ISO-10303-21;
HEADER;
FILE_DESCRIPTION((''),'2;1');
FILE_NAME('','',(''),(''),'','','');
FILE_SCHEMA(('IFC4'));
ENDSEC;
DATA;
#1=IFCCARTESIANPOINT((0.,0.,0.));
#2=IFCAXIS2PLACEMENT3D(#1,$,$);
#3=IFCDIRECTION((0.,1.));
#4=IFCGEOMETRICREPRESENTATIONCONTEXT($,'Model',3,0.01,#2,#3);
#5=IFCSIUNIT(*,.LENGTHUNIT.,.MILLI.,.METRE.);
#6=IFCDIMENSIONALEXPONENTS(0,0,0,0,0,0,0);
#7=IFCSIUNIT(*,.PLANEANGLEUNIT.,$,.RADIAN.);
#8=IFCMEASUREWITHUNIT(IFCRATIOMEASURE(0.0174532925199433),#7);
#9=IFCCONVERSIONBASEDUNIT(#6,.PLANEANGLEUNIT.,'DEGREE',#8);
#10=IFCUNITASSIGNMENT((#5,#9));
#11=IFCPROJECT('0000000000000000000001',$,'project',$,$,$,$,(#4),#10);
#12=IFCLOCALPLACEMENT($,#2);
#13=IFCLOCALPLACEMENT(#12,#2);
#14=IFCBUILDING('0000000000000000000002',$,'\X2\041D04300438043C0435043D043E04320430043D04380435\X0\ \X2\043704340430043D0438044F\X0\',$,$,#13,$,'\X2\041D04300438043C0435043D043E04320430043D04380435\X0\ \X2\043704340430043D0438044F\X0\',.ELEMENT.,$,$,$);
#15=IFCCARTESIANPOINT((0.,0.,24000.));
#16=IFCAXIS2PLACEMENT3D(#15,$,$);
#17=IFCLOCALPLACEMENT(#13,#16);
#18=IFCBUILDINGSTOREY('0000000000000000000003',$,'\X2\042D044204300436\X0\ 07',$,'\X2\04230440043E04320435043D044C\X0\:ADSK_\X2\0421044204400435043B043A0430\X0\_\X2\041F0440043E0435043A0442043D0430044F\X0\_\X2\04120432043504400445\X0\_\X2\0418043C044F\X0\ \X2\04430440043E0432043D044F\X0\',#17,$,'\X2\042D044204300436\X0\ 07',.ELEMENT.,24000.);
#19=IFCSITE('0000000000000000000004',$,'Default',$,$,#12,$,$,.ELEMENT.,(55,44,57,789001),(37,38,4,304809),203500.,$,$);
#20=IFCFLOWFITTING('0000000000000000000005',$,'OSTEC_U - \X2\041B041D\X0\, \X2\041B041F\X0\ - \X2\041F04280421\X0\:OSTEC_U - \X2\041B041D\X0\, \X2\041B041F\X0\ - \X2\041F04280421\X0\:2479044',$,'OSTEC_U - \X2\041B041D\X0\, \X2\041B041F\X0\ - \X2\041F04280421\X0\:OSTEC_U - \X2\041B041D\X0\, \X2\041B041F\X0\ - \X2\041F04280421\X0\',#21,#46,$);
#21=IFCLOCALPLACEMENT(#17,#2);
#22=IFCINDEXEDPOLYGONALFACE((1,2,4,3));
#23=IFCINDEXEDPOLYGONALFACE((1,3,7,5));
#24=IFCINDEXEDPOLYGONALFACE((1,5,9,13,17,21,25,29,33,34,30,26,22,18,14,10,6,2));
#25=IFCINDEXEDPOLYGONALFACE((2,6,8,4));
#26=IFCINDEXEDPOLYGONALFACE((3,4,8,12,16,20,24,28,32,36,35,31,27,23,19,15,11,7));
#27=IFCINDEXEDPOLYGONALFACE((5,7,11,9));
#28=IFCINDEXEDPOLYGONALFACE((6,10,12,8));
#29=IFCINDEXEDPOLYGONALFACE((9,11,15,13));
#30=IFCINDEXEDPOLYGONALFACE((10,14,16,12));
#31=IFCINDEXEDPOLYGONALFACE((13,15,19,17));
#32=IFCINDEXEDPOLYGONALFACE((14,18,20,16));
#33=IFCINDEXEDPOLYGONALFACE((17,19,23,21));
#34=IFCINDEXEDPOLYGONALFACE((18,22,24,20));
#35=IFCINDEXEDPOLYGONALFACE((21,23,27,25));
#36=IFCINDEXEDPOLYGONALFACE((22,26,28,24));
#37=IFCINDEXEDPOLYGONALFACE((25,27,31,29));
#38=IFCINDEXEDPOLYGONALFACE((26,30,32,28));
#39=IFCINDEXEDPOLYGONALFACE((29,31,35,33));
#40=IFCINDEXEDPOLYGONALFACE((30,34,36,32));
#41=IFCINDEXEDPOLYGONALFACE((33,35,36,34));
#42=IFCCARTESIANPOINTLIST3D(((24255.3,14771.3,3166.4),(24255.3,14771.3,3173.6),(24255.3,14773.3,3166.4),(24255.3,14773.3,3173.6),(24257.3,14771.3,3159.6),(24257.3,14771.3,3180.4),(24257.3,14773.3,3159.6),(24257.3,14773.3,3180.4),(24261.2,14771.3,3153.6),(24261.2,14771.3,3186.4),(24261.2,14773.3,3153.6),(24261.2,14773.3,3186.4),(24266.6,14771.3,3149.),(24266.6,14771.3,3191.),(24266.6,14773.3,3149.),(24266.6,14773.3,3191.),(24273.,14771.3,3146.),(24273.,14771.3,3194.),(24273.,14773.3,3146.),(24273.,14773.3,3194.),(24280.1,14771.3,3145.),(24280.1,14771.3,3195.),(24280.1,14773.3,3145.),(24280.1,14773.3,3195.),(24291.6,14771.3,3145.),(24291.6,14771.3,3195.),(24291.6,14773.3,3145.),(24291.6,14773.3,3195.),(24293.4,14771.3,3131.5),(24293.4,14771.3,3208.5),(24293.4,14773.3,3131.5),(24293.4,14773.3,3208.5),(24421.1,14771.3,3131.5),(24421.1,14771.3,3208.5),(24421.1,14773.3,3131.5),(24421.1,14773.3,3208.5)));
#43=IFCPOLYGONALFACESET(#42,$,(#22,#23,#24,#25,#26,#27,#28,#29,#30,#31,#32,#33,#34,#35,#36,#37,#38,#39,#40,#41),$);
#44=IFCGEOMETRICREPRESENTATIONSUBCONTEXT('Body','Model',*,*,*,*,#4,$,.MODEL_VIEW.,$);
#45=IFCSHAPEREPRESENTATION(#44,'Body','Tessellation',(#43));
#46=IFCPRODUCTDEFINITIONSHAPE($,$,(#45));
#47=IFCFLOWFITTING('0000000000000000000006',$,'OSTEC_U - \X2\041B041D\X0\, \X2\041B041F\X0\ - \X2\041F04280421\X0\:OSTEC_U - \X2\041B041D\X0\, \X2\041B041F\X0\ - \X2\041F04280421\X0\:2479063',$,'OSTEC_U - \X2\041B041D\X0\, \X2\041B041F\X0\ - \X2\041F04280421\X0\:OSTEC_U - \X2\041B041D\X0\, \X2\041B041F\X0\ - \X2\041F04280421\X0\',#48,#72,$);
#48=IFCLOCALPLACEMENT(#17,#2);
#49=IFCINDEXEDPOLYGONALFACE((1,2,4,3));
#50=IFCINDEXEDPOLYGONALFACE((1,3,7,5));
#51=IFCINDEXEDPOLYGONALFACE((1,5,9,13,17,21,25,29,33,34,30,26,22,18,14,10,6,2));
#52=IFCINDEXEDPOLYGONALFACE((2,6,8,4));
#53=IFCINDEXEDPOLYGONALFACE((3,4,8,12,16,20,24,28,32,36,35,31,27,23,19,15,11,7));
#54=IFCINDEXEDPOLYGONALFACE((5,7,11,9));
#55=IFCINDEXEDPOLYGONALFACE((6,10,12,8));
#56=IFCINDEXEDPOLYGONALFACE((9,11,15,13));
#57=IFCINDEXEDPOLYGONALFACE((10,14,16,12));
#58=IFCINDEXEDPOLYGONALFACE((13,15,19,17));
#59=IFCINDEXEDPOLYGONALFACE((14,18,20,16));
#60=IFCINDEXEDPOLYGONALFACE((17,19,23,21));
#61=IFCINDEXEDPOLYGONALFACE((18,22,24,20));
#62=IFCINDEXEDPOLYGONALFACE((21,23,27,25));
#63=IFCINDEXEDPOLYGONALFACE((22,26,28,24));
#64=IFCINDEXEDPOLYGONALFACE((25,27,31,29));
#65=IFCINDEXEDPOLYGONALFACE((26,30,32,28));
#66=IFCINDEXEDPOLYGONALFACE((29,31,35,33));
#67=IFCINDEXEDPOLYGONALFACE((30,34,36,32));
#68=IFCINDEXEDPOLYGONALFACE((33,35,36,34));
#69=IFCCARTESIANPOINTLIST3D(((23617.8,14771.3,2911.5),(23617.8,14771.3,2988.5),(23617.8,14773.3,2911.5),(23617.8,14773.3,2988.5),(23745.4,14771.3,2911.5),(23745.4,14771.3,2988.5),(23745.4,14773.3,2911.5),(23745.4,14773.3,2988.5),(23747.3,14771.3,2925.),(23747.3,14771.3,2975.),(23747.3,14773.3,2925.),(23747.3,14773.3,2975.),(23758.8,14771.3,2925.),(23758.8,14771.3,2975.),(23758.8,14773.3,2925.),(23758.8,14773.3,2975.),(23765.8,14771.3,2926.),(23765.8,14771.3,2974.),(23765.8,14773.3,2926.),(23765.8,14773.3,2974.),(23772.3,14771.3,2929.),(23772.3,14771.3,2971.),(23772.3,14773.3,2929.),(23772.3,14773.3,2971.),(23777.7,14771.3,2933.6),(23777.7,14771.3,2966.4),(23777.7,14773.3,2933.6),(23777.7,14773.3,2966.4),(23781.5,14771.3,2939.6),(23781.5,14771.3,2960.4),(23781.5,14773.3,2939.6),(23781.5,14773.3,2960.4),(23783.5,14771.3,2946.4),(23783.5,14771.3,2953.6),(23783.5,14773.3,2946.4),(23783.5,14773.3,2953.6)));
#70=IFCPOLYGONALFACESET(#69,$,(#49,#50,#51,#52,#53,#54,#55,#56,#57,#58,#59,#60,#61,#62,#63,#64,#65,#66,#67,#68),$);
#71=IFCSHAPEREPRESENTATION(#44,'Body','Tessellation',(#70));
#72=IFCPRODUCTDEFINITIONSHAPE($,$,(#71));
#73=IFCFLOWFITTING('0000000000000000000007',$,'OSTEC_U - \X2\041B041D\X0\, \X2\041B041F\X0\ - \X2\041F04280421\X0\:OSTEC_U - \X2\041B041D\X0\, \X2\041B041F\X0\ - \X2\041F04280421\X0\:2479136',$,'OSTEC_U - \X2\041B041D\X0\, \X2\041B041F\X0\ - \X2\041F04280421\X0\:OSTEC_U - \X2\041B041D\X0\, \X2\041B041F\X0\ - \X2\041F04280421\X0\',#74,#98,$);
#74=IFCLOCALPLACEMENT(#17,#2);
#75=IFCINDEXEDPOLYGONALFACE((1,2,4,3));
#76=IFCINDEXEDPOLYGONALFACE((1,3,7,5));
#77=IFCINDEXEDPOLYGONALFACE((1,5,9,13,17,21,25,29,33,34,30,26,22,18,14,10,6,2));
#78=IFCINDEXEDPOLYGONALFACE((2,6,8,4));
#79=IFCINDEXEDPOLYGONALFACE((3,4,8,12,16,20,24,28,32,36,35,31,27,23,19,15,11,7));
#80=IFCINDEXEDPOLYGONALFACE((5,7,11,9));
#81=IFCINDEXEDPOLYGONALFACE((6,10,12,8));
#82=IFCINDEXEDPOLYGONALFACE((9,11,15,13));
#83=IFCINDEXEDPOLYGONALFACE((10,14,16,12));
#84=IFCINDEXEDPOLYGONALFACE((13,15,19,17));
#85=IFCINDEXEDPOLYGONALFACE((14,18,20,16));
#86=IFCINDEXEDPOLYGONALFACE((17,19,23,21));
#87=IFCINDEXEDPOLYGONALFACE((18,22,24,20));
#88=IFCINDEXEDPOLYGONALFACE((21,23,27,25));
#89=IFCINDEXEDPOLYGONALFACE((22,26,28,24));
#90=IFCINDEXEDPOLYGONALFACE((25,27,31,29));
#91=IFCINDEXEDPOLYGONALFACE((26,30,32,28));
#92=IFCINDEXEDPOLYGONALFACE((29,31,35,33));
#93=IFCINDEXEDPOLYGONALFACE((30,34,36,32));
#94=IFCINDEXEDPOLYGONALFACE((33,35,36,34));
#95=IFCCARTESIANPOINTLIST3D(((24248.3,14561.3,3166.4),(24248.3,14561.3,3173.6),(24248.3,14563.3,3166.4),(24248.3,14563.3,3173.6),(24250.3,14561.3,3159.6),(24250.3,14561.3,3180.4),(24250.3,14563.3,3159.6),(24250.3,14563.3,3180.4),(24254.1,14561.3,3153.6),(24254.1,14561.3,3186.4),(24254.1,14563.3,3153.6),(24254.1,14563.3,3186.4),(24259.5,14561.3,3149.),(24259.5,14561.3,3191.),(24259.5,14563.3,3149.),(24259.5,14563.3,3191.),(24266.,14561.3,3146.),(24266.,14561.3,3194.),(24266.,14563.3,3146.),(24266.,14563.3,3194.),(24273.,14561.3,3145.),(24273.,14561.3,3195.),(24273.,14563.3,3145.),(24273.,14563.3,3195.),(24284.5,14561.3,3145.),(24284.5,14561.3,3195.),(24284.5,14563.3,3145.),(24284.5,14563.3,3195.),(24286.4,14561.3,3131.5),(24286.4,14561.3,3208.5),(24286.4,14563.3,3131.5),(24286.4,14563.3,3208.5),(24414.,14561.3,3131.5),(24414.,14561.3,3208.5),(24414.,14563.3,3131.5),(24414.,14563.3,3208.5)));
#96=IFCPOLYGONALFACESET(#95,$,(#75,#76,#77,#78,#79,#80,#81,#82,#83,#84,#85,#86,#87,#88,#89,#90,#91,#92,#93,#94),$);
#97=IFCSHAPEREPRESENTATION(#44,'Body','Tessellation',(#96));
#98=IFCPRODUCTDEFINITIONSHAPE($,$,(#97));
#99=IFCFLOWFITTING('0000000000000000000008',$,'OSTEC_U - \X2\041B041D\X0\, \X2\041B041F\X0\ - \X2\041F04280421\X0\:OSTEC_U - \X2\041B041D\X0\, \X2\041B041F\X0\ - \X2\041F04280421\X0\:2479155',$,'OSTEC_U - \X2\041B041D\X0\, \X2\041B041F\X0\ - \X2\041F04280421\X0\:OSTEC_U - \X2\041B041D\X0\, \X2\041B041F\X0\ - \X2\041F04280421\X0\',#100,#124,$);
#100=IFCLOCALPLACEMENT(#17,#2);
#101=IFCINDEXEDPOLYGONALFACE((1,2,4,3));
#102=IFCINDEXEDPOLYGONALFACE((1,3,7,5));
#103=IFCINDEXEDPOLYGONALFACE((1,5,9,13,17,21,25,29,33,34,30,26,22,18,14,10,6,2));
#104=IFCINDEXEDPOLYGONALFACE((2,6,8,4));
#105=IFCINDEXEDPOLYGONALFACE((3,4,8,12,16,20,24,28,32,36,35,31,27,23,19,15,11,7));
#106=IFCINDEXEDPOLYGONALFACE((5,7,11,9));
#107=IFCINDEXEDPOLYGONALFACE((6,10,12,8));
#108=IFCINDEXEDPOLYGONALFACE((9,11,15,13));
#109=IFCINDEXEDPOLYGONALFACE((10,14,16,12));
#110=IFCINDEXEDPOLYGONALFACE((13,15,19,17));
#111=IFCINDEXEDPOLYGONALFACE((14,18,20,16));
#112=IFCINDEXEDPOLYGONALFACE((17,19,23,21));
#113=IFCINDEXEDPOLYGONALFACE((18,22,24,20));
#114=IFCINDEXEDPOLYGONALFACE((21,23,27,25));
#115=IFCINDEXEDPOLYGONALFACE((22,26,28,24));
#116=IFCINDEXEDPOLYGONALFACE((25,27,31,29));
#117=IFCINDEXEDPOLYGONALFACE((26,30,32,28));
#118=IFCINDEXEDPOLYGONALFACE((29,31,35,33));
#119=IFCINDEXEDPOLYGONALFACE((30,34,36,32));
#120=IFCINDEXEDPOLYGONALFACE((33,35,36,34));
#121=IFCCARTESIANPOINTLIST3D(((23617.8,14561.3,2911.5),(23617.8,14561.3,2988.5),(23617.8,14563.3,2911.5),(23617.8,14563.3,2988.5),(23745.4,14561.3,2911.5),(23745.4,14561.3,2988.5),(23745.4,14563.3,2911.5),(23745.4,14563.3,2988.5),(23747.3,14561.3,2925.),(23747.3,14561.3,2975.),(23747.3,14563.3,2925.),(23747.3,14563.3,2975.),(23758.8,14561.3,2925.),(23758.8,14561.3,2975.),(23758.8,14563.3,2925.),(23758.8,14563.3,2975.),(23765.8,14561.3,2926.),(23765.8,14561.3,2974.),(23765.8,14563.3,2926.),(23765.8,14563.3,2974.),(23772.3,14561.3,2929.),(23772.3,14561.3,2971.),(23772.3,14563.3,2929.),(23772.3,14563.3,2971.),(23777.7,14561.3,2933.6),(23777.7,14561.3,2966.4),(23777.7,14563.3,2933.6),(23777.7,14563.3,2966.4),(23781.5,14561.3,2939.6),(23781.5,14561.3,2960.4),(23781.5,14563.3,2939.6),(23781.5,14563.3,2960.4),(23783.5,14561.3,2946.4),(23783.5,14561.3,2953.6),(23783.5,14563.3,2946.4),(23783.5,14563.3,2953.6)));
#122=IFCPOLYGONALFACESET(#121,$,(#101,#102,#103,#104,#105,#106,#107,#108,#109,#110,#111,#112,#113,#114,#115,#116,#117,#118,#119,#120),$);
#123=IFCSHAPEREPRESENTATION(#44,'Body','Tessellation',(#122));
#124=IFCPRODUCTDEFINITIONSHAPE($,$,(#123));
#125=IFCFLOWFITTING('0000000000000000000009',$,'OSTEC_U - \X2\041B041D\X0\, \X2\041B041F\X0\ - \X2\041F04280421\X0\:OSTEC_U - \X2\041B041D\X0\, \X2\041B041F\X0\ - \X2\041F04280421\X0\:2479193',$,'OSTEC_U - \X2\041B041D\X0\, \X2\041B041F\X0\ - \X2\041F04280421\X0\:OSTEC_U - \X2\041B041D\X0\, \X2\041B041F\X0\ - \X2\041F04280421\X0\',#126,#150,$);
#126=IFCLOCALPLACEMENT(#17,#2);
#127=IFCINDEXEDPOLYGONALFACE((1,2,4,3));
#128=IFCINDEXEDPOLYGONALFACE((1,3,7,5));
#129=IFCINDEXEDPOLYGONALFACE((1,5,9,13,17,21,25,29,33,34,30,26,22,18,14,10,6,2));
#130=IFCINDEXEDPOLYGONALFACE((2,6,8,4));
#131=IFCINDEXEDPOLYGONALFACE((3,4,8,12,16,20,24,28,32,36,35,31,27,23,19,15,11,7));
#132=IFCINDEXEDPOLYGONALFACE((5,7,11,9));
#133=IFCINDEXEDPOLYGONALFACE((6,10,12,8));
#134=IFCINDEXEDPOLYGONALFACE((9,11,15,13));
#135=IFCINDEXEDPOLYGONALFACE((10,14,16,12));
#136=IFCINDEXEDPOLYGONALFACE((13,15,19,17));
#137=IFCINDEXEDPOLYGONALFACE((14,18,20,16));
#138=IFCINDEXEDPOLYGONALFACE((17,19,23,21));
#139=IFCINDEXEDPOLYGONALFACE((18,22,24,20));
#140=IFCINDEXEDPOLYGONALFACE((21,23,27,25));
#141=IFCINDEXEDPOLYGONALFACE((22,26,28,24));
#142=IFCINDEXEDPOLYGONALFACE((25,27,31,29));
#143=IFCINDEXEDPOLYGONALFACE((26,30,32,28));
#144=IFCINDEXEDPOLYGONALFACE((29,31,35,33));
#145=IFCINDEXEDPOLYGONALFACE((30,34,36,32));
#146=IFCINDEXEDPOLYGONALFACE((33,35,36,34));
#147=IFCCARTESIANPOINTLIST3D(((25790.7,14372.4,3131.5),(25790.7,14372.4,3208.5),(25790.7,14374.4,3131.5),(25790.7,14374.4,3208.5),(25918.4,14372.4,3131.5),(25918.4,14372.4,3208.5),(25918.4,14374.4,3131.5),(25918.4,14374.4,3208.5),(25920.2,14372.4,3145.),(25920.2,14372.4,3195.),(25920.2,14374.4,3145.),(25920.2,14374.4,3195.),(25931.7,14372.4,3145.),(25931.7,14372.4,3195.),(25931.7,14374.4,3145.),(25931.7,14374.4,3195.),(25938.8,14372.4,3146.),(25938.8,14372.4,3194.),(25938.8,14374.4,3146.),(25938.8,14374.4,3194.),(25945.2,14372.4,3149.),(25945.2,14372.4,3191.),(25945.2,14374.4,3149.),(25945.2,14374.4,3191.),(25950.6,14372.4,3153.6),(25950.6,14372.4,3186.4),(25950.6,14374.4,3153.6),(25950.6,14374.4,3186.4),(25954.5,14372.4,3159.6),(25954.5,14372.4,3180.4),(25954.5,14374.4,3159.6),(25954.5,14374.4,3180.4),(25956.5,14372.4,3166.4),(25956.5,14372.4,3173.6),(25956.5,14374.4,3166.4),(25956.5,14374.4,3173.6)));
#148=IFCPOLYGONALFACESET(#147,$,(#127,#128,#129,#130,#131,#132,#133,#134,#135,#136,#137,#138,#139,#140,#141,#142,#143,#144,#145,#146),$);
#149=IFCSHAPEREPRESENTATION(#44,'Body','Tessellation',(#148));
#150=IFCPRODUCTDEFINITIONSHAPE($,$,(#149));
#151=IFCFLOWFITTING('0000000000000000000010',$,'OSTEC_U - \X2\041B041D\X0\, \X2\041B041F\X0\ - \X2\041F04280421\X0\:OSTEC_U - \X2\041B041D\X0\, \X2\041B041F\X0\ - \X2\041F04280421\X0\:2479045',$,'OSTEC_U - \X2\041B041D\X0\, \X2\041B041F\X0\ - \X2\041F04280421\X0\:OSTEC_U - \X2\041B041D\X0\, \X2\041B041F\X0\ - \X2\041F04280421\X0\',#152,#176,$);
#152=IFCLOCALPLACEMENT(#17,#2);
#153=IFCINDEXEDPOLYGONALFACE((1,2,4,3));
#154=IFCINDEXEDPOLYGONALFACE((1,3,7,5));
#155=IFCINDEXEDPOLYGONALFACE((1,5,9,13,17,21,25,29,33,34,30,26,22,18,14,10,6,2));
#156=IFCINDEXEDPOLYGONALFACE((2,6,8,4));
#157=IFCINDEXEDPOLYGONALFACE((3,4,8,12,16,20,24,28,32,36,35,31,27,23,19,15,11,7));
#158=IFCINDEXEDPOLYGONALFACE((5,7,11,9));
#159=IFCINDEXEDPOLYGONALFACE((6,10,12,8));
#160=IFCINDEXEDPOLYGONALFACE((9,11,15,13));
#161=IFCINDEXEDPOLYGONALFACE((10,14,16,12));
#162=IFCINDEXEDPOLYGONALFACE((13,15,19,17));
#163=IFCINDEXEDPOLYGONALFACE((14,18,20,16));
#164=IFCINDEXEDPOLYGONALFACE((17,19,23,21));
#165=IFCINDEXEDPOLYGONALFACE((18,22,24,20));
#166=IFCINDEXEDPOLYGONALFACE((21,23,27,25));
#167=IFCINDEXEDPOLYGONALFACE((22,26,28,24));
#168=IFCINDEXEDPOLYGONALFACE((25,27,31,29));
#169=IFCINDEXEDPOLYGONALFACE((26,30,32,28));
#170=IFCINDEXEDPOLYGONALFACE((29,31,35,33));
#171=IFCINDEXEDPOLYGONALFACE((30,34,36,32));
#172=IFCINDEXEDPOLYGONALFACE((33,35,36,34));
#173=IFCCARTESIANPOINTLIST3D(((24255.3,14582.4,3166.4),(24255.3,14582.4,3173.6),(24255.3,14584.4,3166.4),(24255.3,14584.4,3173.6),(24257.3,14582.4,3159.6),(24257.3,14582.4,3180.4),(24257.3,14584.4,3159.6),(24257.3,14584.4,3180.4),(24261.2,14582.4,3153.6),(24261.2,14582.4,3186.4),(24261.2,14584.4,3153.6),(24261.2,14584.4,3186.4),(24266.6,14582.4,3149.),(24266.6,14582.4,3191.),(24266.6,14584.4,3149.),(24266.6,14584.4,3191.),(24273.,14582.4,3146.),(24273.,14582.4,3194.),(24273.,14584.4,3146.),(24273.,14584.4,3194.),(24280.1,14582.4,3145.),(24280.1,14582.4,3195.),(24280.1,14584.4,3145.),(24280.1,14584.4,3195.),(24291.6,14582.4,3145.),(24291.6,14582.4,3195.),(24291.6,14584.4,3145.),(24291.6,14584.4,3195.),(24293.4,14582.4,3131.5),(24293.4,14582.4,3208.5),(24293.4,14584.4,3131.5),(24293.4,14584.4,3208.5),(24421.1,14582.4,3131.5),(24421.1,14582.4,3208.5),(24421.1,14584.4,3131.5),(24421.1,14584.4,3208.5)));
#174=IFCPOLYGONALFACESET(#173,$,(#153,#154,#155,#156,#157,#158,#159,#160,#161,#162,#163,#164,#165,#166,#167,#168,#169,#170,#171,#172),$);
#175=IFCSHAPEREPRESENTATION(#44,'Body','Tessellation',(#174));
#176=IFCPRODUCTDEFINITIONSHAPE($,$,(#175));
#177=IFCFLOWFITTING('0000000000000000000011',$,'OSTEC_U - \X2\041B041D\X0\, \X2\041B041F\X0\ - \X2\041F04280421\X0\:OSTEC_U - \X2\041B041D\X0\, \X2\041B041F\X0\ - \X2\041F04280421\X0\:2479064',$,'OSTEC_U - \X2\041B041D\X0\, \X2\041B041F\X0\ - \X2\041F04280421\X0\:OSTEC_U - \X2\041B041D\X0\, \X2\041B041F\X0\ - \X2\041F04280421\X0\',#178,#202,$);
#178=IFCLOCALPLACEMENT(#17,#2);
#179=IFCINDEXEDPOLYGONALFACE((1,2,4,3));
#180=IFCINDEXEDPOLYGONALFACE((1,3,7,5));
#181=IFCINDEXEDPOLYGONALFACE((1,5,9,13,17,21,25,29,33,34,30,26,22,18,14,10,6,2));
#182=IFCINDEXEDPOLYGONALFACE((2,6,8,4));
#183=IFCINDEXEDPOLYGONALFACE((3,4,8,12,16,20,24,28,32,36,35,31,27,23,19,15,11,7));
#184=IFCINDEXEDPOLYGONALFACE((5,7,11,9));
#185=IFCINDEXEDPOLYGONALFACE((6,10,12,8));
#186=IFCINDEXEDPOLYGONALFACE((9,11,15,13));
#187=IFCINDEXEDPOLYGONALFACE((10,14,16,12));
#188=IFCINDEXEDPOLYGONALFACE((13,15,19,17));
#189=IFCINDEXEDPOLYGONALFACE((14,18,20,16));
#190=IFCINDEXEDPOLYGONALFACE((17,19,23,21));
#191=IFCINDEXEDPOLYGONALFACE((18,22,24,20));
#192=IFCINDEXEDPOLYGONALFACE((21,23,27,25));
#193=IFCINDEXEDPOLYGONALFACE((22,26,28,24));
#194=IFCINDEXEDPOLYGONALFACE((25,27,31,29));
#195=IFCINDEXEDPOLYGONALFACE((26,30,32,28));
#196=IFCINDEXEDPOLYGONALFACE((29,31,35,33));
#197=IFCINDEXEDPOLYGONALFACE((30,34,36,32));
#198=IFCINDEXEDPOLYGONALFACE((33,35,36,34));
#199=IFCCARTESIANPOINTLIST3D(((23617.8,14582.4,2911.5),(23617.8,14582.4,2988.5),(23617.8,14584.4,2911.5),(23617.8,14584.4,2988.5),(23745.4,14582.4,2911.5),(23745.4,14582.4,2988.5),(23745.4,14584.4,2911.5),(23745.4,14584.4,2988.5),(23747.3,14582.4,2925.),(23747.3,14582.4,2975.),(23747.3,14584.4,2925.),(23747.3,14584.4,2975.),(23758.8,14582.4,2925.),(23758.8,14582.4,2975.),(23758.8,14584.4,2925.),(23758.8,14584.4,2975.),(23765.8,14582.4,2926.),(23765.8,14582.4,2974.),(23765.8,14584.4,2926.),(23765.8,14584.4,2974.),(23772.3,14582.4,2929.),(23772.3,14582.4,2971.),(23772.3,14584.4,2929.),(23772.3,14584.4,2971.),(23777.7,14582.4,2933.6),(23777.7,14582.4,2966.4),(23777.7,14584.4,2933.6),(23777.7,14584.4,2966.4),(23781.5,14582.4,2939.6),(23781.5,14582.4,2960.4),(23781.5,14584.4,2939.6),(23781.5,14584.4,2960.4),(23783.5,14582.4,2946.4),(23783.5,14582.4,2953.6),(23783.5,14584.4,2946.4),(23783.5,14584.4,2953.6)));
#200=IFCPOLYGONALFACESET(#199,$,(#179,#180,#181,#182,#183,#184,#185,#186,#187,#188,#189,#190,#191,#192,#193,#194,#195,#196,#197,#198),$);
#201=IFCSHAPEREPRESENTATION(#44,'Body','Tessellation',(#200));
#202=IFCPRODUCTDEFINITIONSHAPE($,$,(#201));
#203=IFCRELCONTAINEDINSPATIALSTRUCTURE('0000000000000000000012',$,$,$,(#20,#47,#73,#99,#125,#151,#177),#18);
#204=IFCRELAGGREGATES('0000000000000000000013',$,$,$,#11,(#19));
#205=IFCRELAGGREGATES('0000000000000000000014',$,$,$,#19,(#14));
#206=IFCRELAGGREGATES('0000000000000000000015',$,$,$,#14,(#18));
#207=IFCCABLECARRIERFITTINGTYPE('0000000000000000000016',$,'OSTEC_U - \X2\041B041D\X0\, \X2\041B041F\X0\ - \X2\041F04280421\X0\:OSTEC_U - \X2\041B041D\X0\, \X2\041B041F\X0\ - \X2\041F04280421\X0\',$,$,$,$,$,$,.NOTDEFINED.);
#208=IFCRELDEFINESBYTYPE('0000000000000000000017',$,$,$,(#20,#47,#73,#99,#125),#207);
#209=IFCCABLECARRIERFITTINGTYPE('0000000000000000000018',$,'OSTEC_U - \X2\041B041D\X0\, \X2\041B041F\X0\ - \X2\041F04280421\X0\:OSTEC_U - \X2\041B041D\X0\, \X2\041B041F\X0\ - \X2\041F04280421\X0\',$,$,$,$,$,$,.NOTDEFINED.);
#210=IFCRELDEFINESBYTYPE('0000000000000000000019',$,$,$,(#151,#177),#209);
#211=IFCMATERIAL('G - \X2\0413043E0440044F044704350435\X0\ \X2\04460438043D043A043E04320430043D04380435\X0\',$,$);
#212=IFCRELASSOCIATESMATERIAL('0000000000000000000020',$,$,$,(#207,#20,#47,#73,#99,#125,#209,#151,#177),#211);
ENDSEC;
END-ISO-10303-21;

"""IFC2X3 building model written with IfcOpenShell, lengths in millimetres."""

from ifc_helpers import new_model, entity, si_unit, converted_unit, direction, frame, frame_2d, origin, place, context, subcontext, project, spatial, polyline, circle_curve, parameter, trimmed, segment, composite_curve, outline, extrude, source, transform, mapped, material, type_object, type_shapes, element, save


model = new_model("IFC2X3")

# Units and contexts
model_context = context("Model", 3, precision=0.01, world=origin(), true_north=direction((0.0, 1.0)))
body_context = subcontext(model_context, "Body", "Model", "MODEL_VIEW")
ifc_project = project(units=[si_unit("LENGTHUNIT", "METRE", prefix="MILLI"), converted_unit("PLANEANGLEUNIT", "DEGREE", entity("IfcRatioMeasure", 0.0174532925199433), si_unit("PLANEANGLEUNIT", "RADIAN"), dimensions=[0, 0, 0, 0, 0, 0, 0])], contexts=[model_context])

# Site, building, storey
site_placement = place(None, frame((0.0, 0.0, 0.0)))
site = spatial("IfcSite", under=ifc_project, at=site_placement, Name="Default", CompositionType="ELEMENT", RefLatitude=(55, 44, 57, 789001), RefLongitude=(37, 38, 4, 304809), RefElevation=203500.0)
building_placement = place(site_placement, origin())
building = spatial("IfcBuilding", under=site, at=building_placement, Name="Наименование здания", LongName="Наименование здания", CompositionType="ELEMENT")
storey_placement = place(building_placement, frame((0.0, 0.0, 24000.0)))
storey = spatial("IfcBuildingStorey", under=building, at=storey_placement, Name="Этаж 07", ObjectType="Уровень:ADSK_Стрелка_Проектная_Вверх_Имя уровня", LongName="Этаж 07", CompositionType="ELEMENT", Elevation=24000.0)

# Flow fittings
ifc_material_1 = material(Name="G - Горячее цинкование")
cable_carrier_fitting_type_1 = type_object("IfcCableCarrierFittingType", Name="OSTEC_U - ЛН, ЛП - ПШС:OSTEC_U - ЛН, ЛП - ПШС", PredefinedType="NOTDEFINED", material=ifc_material_1)
shared_shape_1 = source(origin(), body_context, "Body", "SweptSolid", [
    extrude(outline(composite_curve([segment(trimmed(circle_curve(frame_2d((-41.5, 0.0), x_axis=(1.0, 0.0)), 25.0), [parameter(90.0)], [parameter(270.0)], True, "PARAMETER"), True, "CONTINUOUS"), segment(polyline([(-41.5, -25.0), (-30.0, -25.0)]), True, "CONTINUOUS"), segment(polyline([(-30.0, -25.0), (-28.1, -38.5)]), True, "CONTINUOUS"), segment(polyline([(-28.1, -38.5), (99.5, -38.5)]), True, "CONTINUOUS"), segment(polyline([(99.5, -38.5), (99.5, 38.5)]), True, "CONTINUOUS"), segment(polyline([(99.5, 38.5), (-28.1, 38.5)]), True, "CONTINUOUS"), segment(polyline([(-28.1, 38.5), (-30.0, 25.0)]), True, "CONTINUOUS"), segment(polyline([(-30.0, 25.0), (-41.5, 25.0)]), True, "CONTINUOUS")], self_intersect=False)), frame((41.5, 0.0, 0.0), z_axis=(0.0, 0.0, -1.0), x_axis=(1.0, 0.0, 0.0)), (0.0, 0.0, -1.0), 2.0),
])
type_shapes(cable_carrier_fitting_type_1, [shared_shape_1])
for number, where, z_axis, x_axis, name in (
    (1, (24280.1, 14771.3, 3170.0), (0.0, 1.0, 0.0), (1.0, 0.0, 0.0), "OSTEC_U - ЛН, ЛП - ПШС:OSTEC_U - ЛН, ЛП - ПШС:2479044"),
    (2, (23758.8, 14771.3, 2950.0), (0.0, 1.0, 0.0), (-1.0, 0.0, 0.0), "OSTEC_U - ЛН, ЛП - ПШС:OSTEC_U - ЛН, ЛП - ПШС:2479063"),
    (3, (24273.0, 14561.3, 3170.0), (0.0, 1.0, 0.0), (1.0, 0.0, 0.0), "OSTEC_U - ЛН, ЛП - ПШС:OSTEC_U - ЛН, ЛП - ПШС:2479136"),
    (4, (23758.8, 14561.3, 2950.0), (0.0, 1.0, 0.0), (-1.0, 0.0, 0.0), "OSTEC_U - ЛН, ЛП - ПШС:OSTEC_U - ЛН, ЛП - ПШС:2479155"),
    (5, (25931.7, 14374.4, 3170.0), (0.0, -1.0, 0.0), (-1.0, 0.0, 0.0), "OSTEC_U - ЛН, ЛП - ПШС:OSTEC_U - ЛН, ЛП - ПШС:2479193"),
):
    element("IfcFlowFitting", number, at=place(storey_placement, frame(where, z_axis=z_axis, x_axis=x_axis)), inside=storey, type_object=cable_carrier_fitting_type_1, material=ifc_material_1, Name=name, ObjectType="OSTEC_U - ЛН, ЛП - ПШС:OSTEC_U - ЛН, ЛП - ПШС", context=body_context, shape_type="MappedRepresentation", body=[
        mapped(shared_shape_1, transform((0.0, 0.0, 0.0), scale=1.0)),
    ])
cable_carrier_fitting_type_2 = type_object("IfcCableCarrierFittingType", Name="OSTEC_U - ЛН, ЛП - ПШС:OSTEC_U - ЛН, ЛП - ПШС", PredefinedType="NOTDEFINED", material=ifc_material_1)
shared_shape_2 = source(origin(), body_context, "Body", "SweptSolid", [
    extrude(outline(composite_curve([segment(trimmed(circle_curve(frame_2d((-41.5, 0.0), x_axis=(1.0, 0.0)), 25.0), [parameter(90.0)], [parameter(270.0)], True, "PARAMETER"), True, "CONTINUOUS"), segment(polyline([(-41.5, -25.0), (-30.0, -25.0)]), True, "CONTINUOUS"), segment(polyline([(-30.0, -25.0), (-28.1, -38.5)]), True, "CONTINUOUS"), segment(polyline([(-28.1, -38.5), (99.5, -38.5)]), True, "CONTINUOUS"), segment(polyline([(99.5, -38.5), (99.5, 38.5)]), True, "CONTINUOUS"), segment(polyline([(99.5, 38.5), (-28.1, 38.5)]), True, "CONTINUOUS"), segment(polyline([(-28.1, 38.5), (-30.0, 25.0)]), True, "CONTINUOUS"), segment(polyline([(-30.0, 25.0), (-41.5, 25.0)]), True, "CONTINUOUS")], self_intersect=False)), frame((41.5, 0.0, 0.0)), (0.0, 0.0, 1.0), 2.0),
])
type_shapes(cable_carrier_fitting_type_2, [shared_shape_2])
for number, where, z_axis, x_axis, name in (
    (6, (24280.1, 14584.4, 3170.0), (0.0, -1.0, 0.0), (1.0, 0.0, 0.0), "OSTEC_U - ЛН, ЛП - ПШС:OSTEC_U - ЛН, ЛП - ПШС:2479045"),
    (7, (23758.8, 14584.4, 2950.0), (0.0, -1.0, 0.0), (-1.0, 0.0, 0.0), "OSTEC_U - ЛН, ЛП - ПШС:OSTEC_U - ЛН, ЛП - ПШС:2479064"),
):
    element("IfcFlowFitting", number, at=place(storey_placement, frame(where, z_axis=z_axis, x_axis=x_axis)), inside=storey, type_object=cable_carrier_fitting_type_2, material=ifc_material_1, Name=name, ObjectType="OSTEC_U - ЛН, ЛП - ПШС:OSTEC_U - ЛН, ЛП - ПШС", context=body_context, shape_type="MappedRepresentation", body=[
        mapped(shared_shape_2, transform((0.0, 0.0, 0.0), scale=1.0)),
    ])

save(model, "model.ifc")
